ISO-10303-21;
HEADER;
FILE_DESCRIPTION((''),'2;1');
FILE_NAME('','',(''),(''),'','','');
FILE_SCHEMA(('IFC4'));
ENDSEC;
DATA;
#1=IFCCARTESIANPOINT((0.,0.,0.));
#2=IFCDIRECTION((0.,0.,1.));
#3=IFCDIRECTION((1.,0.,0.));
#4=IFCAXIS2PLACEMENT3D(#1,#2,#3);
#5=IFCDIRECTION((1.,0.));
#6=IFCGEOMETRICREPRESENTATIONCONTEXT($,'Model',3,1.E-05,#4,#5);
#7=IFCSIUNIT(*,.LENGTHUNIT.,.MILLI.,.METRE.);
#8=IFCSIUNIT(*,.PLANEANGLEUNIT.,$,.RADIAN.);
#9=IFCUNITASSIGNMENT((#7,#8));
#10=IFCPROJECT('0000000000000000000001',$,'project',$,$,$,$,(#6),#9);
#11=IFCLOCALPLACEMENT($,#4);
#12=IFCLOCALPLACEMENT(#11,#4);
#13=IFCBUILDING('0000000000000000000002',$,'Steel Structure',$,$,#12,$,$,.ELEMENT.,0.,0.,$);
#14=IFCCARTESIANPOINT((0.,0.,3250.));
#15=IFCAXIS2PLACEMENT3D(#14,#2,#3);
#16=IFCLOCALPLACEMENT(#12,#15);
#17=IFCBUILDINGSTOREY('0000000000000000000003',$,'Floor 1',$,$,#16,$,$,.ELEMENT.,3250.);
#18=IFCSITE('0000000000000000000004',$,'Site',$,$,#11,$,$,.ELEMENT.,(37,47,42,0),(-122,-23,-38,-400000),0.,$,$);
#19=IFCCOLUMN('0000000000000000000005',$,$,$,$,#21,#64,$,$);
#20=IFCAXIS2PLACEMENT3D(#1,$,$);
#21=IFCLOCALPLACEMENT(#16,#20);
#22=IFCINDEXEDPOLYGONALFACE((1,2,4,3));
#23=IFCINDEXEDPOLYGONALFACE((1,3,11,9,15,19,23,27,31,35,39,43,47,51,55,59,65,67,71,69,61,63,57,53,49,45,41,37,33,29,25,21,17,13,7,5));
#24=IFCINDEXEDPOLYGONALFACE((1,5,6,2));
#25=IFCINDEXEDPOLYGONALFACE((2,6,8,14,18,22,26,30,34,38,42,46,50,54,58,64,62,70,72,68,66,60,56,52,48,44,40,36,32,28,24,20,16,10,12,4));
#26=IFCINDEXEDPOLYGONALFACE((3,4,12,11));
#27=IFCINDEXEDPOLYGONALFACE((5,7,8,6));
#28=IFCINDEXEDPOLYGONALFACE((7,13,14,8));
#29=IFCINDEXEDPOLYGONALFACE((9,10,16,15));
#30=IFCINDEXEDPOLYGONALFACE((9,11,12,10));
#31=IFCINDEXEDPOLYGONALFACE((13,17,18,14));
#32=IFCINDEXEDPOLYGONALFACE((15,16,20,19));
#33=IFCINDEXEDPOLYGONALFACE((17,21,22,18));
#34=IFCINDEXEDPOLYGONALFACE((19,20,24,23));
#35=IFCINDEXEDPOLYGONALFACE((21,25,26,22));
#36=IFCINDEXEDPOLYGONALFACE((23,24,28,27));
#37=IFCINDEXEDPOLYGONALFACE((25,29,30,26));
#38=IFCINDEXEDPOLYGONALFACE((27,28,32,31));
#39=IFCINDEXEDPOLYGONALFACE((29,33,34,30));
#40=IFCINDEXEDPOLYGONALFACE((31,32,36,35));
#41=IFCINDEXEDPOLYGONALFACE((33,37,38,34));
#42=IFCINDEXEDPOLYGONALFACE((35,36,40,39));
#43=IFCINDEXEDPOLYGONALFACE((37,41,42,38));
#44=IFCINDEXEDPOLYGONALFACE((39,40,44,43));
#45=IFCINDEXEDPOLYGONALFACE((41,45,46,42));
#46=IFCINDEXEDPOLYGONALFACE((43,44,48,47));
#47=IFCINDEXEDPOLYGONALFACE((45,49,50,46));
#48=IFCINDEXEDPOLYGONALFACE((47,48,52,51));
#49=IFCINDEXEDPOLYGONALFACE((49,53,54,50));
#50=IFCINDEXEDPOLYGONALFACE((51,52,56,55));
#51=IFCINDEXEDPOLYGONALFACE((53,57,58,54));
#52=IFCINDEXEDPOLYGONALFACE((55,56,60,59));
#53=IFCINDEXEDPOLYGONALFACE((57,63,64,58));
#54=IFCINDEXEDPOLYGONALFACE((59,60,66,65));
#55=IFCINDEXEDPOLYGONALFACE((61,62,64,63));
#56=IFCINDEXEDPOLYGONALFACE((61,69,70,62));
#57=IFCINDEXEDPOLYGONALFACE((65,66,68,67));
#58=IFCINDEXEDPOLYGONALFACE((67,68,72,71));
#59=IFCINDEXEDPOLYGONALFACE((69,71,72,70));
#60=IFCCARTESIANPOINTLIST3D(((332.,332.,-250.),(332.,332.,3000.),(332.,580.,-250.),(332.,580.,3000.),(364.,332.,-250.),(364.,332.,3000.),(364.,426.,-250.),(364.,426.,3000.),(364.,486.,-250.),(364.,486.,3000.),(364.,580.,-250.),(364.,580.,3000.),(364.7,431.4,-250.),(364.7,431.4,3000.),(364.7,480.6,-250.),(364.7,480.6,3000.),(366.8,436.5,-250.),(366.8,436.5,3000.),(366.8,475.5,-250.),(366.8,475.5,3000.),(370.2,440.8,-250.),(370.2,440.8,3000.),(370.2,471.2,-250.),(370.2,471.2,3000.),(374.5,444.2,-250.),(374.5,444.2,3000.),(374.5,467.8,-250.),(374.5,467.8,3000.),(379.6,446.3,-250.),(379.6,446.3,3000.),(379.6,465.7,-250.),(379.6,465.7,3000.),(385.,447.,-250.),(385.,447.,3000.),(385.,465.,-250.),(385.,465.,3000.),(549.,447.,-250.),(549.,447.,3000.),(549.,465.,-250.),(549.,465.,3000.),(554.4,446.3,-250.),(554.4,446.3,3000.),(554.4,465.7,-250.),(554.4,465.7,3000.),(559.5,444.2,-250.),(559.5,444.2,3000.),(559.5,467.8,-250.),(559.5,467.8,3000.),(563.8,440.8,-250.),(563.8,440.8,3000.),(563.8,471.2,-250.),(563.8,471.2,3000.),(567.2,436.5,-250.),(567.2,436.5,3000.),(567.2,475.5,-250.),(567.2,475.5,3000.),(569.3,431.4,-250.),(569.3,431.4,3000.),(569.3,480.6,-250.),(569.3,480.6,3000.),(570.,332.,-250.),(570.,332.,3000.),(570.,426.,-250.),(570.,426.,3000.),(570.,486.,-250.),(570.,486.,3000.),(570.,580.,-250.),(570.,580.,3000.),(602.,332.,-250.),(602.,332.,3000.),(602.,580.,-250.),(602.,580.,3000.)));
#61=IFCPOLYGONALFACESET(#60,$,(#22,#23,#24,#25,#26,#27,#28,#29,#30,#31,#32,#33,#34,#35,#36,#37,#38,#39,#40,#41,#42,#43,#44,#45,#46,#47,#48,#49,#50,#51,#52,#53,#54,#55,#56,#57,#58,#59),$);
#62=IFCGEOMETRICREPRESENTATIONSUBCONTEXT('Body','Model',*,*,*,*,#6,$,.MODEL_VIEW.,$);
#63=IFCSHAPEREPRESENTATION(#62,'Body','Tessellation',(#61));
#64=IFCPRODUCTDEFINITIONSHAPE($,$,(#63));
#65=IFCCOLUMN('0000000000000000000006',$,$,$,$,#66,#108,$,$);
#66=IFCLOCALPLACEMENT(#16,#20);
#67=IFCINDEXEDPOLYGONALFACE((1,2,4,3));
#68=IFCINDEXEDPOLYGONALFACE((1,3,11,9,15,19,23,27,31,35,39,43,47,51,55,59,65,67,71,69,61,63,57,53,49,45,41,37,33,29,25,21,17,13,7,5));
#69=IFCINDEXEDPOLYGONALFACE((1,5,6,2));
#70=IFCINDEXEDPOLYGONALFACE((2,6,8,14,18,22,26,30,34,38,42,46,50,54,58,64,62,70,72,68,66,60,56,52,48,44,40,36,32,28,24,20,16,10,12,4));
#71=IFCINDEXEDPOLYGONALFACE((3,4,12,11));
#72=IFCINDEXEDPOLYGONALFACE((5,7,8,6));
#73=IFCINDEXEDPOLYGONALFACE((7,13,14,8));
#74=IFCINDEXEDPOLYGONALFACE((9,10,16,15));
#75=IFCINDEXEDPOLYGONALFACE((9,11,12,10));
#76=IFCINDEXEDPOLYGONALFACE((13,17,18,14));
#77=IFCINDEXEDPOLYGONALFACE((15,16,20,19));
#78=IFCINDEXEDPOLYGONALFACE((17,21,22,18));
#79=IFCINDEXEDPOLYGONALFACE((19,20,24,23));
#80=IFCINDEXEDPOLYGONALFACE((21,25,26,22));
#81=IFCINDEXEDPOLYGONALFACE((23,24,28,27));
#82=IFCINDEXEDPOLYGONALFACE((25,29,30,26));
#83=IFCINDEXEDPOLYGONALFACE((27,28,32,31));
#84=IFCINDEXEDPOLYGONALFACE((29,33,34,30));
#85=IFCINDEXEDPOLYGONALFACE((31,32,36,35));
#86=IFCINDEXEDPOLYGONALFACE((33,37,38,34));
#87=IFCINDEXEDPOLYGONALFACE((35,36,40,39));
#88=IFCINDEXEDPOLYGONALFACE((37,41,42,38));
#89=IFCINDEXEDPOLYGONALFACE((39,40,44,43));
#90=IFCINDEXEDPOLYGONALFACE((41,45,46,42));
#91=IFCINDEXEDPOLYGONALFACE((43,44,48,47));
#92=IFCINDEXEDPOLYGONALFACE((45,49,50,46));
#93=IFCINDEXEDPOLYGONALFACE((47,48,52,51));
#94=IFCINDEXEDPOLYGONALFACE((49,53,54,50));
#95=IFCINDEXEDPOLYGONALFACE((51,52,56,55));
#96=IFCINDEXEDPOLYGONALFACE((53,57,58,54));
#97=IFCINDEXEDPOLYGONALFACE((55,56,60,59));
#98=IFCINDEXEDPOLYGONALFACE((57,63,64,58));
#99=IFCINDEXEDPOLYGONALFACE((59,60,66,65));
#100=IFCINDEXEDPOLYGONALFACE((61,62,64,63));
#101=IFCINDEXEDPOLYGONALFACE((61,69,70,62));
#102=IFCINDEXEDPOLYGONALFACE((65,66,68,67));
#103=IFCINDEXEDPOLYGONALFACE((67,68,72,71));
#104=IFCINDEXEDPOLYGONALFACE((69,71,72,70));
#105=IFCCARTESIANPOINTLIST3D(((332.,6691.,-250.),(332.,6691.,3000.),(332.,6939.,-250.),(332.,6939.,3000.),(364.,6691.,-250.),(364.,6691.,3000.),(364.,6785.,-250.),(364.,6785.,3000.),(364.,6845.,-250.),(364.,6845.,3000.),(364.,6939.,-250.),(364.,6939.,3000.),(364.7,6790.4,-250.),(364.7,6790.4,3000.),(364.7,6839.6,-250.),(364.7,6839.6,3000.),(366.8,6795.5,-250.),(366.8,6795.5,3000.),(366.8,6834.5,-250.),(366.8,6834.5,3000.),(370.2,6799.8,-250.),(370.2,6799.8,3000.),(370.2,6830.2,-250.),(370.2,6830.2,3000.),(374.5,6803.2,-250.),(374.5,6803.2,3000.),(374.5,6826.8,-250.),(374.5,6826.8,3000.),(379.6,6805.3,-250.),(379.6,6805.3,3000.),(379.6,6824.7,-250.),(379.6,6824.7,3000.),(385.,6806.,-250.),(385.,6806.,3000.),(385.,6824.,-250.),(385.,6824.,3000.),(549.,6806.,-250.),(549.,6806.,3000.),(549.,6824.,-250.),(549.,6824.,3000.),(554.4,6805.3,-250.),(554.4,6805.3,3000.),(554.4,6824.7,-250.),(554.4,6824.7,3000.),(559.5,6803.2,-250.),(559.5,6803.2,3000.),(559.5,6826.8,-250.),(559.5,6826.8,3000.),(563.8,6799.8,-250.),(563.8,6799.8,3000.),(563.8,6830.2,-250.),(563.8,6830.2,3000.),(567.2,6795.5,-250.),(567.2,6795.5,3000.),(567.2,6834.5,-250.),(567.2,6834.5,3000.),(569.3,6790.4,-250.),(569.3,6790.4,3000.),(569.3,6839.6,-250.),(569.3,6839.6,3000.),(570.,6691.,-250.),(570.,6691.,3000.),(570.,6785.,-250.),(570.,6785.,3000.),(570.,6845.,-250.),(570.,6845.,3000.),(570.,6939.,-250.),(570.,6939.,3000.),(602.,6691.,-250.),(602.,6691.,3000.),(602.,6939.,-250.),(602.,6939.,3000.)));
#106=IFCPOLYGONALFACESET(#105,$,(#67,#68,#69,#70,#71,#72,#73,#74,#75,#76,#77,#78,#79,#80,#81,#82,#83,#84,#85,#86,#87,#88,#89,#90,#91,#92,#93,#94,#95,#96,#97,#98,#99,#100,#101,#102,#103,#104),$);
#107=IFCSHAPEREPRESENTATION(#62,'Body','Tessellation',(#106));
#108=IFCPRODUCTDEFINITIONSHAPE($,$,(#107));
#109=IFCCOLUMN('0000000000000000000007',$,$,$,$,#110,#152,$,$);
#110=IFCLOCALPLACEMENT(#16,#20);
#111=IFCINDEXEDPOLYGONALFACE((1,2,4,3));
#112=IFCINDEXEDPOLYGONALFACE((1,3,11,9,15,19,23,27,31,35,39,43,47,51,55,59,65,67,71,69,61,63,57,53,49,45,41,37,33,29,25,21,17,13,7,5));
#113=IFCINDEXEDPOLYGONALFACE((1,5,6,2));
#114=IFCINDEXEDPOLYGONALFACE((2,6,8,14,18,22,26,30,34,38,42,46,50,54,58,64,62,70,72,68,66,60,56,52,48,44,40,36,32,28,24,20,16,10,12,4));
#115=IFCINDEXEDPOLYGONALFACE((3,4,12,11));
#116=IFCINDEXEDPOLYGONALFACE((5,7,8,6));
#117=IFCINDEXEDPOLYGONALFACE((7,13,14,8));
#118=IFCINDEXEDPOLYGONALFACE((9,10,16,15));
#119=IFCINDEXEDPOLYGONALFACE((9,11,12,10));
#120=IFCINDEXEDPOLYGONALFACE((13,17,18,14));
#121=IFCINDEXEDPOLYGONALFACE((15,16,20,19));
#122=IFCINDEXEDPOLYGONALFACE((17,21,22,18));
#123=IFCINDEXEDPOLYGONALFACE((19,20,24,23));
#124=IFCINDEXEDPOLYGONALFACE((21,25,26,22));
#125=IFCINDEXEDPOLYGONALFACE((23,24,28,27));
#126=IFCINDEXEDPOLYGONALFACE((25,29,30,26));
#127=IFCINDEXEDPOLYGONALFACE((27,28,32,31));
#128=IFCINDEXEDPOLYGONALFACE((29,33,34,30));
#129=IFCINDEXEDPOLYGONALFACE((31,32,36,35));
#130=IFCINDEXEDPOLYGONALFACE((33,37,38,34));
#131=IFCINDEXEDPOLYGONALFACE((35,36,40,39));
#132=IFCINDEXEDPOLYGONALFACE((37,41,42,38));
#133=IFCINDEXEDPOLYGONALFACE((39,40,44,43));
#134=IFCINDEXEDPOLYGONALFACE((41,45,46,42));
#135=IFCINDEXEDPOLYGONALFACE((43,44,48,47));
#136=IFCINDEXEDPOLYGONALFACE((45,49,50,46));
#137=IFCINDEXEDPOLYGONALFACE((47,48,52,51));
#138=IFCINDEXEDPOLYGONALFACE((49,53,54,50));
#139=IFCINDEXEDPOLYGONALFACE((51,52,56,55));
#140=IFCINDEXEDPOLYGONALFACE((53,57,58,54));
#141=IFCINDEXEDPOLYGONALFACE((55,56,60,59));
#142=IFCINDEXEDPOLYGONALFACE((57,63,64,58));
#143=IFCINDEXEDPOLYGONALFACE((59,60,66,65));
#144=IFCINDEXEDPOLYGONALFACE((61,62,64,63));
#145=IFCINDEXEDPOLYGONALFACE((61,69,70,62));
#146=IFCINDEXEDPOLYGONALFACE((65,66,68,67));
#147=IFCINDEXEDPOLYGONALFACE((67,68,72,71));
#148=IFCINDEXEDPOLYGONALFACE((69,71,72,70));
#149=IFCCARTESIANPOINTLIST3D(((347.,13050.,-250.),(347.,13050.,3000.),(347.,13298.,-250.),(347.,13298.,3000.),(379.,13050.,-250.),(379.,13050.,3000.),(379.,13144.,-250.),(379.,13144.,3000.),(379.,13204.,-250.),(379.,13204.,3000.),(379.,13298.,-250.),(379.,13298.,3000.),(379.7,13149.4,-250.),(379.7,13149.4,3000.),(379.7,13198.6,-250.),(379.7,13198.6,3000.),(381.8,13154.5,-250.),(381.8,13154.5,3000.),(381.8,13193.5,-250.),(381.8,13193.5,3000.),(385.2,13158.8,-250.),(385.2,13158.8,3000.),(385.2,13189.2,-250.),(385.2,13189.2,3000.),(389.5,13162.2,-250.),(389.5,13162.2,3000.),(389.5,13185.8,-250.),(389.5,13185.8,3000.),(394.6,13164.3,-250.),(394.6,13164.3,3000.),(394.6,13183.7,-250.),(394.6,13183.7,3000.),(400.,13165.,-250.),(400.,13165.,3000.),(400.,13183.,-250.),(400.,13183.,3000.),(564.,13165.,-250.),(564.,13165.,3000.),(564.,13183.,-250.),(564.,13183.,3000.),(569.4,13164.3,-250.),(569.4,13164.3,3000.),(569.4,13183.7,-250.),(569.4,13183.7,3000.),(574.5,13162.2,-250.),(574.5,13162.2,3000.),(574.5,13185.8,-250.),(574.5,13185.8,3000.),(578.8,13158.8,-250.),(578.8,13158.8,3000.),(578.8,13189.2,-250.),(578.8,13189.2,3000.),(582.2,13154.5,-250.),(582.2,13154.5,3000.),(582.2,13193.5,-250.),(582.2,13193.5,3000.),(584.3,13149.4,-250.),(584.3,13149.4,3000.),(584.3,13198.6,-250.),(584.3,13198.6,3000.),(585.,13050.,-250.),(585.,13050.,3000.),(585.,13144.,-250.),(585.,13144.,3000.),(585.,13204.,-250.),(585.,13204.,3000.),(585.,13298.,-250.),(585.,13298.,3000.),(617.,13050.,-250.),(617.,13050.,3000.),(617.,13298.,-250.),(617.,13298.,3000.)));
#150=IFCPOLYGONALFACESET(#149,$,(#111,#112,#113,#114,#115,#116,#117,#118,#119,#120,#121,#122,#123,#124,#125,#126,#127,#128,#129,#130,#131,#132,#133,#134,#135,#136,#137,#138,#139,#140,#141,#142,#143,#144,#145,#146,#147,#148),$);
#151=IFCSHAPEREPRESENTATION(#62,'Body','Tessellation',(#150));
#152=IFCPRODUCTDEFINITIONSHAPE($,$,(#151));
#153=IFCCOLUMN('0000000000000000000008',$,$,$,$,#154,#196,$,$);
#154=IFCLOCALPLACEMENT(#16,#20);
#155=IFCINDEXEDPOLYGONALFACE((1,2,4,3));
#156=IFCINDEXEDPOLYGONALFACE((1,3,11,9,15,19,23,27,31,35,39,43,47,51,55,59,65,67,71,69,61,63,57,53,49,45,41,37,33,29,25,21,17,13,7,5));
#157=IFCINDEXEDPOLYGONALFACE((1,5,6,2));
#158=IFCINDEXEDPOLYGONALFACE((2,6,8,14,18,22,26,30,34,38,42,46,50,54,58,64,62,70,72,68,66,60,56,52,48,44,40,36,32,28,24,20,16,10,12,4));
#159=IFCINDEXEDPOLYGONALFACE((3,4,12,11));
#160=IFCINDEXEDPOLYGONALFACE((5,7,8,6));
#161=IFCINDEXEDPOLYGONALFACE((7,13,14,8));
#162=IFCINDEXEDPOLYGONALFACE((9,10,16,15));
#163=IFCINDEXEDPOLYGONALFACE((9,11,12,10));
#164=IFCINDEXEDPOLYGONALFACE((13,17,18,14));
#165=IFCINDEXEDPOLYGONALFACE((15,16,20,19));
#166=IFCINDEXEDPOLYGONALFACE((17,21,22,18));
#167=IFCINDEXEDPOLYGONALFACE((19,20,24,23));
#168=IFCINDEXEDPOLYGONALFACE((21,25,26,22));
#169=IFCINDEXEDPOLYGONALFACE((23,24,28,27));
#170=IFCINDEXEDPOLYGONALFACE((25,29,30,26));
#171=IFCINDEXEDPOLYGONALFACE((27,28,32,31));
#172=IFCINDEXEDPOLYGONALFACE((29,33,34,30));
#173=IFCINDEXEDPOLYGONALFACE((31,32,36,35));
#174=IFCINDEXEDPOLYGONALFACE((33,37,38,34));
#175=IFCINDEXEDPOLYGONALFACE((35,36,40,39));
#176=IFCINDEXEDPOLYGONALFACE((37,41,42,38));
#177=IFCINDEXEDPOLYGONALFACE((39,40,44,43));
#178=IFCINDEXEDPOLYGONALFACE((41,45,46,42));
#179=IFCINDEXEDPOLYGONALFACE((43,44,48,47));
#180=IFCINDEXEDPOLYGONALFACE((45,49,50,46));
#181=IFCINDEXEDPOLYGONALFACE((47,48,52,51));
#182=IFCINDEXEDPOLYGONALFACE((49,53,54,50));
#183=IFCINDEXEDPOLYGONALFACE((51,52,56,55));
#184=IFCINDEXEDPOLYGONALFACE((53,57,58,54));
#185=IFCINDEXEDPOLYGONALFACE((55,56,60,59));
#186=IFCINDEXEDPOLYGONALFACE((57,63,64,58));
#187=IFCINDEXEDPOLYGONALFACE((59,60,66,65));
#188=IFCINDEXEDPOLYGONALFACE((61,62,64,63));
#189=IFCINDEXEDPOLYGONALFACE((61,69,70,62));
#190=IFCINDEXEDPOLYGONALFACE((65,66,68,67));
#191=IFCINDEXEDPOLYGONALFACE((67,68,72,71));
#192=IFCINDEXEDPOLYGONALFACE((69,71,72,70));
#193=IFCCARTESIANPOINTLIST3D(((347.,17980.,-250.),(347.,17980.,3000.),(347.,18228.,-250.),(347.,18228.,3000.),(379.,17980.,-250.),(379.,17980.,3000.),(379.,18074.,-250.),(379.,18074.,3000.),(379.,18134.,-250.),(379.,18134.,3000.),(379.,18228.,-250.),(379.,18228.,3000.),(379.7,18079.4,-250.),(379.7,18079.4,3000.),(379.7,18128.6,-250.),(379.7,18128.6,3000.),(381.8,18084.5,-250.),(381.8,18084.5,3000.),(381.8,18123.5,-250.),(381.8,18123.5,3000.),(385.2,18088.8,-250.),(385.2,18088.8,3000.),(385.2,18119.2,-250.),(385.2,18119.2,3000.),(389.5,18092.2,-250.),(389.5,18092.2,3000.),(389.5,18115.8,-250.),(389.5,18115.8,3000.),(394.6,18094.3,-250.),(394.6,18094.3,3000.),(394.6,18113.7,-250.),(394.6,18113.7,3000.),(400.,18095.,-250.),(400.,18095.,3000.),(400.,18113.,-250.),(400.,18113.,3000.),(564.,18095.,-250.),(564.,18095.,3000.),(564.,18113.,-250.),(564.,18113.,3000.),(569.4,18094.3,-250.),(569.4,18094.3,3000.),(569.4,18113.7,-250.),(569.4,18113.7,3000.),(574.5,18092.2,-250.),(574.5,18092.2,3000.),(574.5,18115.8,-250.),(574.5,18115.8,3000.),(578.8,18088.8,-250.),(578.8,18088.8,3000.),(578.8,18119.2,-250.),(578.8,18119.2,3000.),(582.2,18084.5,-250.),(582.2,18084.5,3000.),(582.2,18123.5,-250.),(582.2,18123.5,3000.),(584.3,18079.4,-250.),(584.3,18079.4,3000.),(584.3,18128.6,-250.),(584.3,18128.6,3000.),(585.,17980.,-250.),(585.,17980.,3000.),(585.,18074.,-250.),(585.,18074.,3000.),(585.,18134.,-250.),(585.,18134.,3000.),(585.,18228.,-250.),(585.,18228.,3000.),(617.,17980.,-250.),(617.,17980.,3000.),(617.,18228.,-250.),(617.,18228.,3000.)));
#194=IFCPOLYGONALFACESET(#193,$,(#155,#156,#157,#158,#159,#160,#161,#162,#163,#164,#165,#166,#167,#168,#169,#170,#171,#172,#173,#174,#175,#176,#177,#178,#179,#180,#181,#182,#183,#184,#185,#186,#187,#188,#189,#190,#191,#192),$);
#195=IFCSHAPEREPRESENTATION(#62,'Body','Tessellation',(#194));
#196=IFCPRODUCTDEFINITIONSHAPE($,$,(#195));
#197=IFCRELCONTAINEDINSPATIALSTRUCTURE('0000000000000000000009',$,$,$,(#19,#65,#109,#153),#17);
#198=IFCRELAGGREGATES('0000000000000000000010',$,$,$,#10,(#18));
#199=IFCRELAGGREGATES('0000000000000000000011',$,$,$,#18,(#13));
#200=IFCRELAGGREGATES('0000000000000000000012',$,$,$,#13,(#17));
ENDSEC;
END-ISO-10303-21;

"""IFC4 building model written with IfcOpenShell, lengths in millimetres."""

from ifc_helpers import new_model, si_unit, direction, frame, origin_with_axes, origin_2d_with_axis, place, context, subcontext, project, spatial, i_section, extrude, element, save


model = new_model("IFC4")

# Units and contexts
model_context = context("Model", 3, precision=1e-05, world=origin_with_axes(), true_north=direction((1.0, 0.0)))
body_context = subcontext(model_context, "Body", "Model", "MODEL_VIEW")
ifc_project = project(units=[si_unit("LENGTHUNIT", "METRE", prefix="MILLI"), si_unit("PLANEANGLEUNIT", "RADIAN")], contexts=[model_context])

# Site, building, storey
site_placement = place(None, origin_with_axes())
site = spatial("IfcSite", under=ifc_project, at=site_placement, Name="Site", CompositionType="ELEMENT", RefLatitude=(37, 47, 42, 0), RefLongitude=(-122, -23, -38, -400000), RefElevation=0.0)
building_placement = place(site_placement, origin_with_axes())
building = spatial("IfcBuilding", under=site, at=building_placement, Name="Steel Structure", CompositionType="ELEMENT", ElevationOfRefHeight=0.0, ElevationOfTerrain=0.0)
storey_placement = place(building_placement, frame((0.0, 0.0, 3250.0), z_axis=(0.0, 0.0, 1.0), x_axis=(1.0, 0.0, 0.0)))
storey = spatial("IfcBuildingStorey", under=building, at=storey_placement, Name="Floor 1", CompositionType="ELEMENT", Elevation=3250.0)

# Columns
column_1_placement = place(storey_placement, frame((467.0, 456.0, -250.0), z_axis=(0.0, 0.0, 1.0), x_axis=(0.0, 1.0, 0.0)))
element("IfcColumn", 1, at=column_1_placement, inside=storey, context=body_context, shape_type="SweptSolid", body=[
    extrude(i_section(OverallWidth=248.0, OverallDepth=270.0, WebThickness=18.0, FlangeThickness=32.0, FilletRadius=21.0, at=origin_2d_with_axis()), origin_with_axes(), (0.0, 0.0, 1.0), 3250.0),
])
column_2_placement = place(storey_placement, frame((467.0, 6815.0, -250.0), z_axis=(0.0, 0.0, 1.0), x_axis=(0.0, -1.0, 0.0)))
element("IfcColumn", 2, at=column_2_placement, inside=storey, context=body_context, shape_type="SweptSolid", body=[
    extrude(i_section(OverallWidth=248.0, OverallDepth=270.0, WebThickness=18.0, FlangeThickness=32.0, FilletRadius=21.0, at=origin_2d_with_axis()), origin_with_axes(), (0.0, 0.0, 1.0), 3250.0),
])
for number, where, z_axis, x_axis in (
    (3, (482.0, 13174.0, -250.0), (0.0, 0.0, 1.0), (0.0, 1.0, 0.0)),
    (4, (482.0, 18104.0, -250.0), (0.0, 0.0, 1.0), (0.0, 1.0, 0.0)),
):
    element("IfcColumn", number, at=place(storey_placement, frame(where, z_axis=z_axis, x_axis=x_axis)), inside=storey, context=body_context, shape_type="SweptSolid", body=[
        extrude(i_section(OverallWidth=248.0, OverallDepth=270.0, WebThickness=18.0, FlangeThickness=32.0, FilletRadius=21.0, at=origin_2d_with_axis()), origin_with_axes(), (0.0, 0.0, 1.0), 3250.0),
    ])

save(model, "model.ifc")
